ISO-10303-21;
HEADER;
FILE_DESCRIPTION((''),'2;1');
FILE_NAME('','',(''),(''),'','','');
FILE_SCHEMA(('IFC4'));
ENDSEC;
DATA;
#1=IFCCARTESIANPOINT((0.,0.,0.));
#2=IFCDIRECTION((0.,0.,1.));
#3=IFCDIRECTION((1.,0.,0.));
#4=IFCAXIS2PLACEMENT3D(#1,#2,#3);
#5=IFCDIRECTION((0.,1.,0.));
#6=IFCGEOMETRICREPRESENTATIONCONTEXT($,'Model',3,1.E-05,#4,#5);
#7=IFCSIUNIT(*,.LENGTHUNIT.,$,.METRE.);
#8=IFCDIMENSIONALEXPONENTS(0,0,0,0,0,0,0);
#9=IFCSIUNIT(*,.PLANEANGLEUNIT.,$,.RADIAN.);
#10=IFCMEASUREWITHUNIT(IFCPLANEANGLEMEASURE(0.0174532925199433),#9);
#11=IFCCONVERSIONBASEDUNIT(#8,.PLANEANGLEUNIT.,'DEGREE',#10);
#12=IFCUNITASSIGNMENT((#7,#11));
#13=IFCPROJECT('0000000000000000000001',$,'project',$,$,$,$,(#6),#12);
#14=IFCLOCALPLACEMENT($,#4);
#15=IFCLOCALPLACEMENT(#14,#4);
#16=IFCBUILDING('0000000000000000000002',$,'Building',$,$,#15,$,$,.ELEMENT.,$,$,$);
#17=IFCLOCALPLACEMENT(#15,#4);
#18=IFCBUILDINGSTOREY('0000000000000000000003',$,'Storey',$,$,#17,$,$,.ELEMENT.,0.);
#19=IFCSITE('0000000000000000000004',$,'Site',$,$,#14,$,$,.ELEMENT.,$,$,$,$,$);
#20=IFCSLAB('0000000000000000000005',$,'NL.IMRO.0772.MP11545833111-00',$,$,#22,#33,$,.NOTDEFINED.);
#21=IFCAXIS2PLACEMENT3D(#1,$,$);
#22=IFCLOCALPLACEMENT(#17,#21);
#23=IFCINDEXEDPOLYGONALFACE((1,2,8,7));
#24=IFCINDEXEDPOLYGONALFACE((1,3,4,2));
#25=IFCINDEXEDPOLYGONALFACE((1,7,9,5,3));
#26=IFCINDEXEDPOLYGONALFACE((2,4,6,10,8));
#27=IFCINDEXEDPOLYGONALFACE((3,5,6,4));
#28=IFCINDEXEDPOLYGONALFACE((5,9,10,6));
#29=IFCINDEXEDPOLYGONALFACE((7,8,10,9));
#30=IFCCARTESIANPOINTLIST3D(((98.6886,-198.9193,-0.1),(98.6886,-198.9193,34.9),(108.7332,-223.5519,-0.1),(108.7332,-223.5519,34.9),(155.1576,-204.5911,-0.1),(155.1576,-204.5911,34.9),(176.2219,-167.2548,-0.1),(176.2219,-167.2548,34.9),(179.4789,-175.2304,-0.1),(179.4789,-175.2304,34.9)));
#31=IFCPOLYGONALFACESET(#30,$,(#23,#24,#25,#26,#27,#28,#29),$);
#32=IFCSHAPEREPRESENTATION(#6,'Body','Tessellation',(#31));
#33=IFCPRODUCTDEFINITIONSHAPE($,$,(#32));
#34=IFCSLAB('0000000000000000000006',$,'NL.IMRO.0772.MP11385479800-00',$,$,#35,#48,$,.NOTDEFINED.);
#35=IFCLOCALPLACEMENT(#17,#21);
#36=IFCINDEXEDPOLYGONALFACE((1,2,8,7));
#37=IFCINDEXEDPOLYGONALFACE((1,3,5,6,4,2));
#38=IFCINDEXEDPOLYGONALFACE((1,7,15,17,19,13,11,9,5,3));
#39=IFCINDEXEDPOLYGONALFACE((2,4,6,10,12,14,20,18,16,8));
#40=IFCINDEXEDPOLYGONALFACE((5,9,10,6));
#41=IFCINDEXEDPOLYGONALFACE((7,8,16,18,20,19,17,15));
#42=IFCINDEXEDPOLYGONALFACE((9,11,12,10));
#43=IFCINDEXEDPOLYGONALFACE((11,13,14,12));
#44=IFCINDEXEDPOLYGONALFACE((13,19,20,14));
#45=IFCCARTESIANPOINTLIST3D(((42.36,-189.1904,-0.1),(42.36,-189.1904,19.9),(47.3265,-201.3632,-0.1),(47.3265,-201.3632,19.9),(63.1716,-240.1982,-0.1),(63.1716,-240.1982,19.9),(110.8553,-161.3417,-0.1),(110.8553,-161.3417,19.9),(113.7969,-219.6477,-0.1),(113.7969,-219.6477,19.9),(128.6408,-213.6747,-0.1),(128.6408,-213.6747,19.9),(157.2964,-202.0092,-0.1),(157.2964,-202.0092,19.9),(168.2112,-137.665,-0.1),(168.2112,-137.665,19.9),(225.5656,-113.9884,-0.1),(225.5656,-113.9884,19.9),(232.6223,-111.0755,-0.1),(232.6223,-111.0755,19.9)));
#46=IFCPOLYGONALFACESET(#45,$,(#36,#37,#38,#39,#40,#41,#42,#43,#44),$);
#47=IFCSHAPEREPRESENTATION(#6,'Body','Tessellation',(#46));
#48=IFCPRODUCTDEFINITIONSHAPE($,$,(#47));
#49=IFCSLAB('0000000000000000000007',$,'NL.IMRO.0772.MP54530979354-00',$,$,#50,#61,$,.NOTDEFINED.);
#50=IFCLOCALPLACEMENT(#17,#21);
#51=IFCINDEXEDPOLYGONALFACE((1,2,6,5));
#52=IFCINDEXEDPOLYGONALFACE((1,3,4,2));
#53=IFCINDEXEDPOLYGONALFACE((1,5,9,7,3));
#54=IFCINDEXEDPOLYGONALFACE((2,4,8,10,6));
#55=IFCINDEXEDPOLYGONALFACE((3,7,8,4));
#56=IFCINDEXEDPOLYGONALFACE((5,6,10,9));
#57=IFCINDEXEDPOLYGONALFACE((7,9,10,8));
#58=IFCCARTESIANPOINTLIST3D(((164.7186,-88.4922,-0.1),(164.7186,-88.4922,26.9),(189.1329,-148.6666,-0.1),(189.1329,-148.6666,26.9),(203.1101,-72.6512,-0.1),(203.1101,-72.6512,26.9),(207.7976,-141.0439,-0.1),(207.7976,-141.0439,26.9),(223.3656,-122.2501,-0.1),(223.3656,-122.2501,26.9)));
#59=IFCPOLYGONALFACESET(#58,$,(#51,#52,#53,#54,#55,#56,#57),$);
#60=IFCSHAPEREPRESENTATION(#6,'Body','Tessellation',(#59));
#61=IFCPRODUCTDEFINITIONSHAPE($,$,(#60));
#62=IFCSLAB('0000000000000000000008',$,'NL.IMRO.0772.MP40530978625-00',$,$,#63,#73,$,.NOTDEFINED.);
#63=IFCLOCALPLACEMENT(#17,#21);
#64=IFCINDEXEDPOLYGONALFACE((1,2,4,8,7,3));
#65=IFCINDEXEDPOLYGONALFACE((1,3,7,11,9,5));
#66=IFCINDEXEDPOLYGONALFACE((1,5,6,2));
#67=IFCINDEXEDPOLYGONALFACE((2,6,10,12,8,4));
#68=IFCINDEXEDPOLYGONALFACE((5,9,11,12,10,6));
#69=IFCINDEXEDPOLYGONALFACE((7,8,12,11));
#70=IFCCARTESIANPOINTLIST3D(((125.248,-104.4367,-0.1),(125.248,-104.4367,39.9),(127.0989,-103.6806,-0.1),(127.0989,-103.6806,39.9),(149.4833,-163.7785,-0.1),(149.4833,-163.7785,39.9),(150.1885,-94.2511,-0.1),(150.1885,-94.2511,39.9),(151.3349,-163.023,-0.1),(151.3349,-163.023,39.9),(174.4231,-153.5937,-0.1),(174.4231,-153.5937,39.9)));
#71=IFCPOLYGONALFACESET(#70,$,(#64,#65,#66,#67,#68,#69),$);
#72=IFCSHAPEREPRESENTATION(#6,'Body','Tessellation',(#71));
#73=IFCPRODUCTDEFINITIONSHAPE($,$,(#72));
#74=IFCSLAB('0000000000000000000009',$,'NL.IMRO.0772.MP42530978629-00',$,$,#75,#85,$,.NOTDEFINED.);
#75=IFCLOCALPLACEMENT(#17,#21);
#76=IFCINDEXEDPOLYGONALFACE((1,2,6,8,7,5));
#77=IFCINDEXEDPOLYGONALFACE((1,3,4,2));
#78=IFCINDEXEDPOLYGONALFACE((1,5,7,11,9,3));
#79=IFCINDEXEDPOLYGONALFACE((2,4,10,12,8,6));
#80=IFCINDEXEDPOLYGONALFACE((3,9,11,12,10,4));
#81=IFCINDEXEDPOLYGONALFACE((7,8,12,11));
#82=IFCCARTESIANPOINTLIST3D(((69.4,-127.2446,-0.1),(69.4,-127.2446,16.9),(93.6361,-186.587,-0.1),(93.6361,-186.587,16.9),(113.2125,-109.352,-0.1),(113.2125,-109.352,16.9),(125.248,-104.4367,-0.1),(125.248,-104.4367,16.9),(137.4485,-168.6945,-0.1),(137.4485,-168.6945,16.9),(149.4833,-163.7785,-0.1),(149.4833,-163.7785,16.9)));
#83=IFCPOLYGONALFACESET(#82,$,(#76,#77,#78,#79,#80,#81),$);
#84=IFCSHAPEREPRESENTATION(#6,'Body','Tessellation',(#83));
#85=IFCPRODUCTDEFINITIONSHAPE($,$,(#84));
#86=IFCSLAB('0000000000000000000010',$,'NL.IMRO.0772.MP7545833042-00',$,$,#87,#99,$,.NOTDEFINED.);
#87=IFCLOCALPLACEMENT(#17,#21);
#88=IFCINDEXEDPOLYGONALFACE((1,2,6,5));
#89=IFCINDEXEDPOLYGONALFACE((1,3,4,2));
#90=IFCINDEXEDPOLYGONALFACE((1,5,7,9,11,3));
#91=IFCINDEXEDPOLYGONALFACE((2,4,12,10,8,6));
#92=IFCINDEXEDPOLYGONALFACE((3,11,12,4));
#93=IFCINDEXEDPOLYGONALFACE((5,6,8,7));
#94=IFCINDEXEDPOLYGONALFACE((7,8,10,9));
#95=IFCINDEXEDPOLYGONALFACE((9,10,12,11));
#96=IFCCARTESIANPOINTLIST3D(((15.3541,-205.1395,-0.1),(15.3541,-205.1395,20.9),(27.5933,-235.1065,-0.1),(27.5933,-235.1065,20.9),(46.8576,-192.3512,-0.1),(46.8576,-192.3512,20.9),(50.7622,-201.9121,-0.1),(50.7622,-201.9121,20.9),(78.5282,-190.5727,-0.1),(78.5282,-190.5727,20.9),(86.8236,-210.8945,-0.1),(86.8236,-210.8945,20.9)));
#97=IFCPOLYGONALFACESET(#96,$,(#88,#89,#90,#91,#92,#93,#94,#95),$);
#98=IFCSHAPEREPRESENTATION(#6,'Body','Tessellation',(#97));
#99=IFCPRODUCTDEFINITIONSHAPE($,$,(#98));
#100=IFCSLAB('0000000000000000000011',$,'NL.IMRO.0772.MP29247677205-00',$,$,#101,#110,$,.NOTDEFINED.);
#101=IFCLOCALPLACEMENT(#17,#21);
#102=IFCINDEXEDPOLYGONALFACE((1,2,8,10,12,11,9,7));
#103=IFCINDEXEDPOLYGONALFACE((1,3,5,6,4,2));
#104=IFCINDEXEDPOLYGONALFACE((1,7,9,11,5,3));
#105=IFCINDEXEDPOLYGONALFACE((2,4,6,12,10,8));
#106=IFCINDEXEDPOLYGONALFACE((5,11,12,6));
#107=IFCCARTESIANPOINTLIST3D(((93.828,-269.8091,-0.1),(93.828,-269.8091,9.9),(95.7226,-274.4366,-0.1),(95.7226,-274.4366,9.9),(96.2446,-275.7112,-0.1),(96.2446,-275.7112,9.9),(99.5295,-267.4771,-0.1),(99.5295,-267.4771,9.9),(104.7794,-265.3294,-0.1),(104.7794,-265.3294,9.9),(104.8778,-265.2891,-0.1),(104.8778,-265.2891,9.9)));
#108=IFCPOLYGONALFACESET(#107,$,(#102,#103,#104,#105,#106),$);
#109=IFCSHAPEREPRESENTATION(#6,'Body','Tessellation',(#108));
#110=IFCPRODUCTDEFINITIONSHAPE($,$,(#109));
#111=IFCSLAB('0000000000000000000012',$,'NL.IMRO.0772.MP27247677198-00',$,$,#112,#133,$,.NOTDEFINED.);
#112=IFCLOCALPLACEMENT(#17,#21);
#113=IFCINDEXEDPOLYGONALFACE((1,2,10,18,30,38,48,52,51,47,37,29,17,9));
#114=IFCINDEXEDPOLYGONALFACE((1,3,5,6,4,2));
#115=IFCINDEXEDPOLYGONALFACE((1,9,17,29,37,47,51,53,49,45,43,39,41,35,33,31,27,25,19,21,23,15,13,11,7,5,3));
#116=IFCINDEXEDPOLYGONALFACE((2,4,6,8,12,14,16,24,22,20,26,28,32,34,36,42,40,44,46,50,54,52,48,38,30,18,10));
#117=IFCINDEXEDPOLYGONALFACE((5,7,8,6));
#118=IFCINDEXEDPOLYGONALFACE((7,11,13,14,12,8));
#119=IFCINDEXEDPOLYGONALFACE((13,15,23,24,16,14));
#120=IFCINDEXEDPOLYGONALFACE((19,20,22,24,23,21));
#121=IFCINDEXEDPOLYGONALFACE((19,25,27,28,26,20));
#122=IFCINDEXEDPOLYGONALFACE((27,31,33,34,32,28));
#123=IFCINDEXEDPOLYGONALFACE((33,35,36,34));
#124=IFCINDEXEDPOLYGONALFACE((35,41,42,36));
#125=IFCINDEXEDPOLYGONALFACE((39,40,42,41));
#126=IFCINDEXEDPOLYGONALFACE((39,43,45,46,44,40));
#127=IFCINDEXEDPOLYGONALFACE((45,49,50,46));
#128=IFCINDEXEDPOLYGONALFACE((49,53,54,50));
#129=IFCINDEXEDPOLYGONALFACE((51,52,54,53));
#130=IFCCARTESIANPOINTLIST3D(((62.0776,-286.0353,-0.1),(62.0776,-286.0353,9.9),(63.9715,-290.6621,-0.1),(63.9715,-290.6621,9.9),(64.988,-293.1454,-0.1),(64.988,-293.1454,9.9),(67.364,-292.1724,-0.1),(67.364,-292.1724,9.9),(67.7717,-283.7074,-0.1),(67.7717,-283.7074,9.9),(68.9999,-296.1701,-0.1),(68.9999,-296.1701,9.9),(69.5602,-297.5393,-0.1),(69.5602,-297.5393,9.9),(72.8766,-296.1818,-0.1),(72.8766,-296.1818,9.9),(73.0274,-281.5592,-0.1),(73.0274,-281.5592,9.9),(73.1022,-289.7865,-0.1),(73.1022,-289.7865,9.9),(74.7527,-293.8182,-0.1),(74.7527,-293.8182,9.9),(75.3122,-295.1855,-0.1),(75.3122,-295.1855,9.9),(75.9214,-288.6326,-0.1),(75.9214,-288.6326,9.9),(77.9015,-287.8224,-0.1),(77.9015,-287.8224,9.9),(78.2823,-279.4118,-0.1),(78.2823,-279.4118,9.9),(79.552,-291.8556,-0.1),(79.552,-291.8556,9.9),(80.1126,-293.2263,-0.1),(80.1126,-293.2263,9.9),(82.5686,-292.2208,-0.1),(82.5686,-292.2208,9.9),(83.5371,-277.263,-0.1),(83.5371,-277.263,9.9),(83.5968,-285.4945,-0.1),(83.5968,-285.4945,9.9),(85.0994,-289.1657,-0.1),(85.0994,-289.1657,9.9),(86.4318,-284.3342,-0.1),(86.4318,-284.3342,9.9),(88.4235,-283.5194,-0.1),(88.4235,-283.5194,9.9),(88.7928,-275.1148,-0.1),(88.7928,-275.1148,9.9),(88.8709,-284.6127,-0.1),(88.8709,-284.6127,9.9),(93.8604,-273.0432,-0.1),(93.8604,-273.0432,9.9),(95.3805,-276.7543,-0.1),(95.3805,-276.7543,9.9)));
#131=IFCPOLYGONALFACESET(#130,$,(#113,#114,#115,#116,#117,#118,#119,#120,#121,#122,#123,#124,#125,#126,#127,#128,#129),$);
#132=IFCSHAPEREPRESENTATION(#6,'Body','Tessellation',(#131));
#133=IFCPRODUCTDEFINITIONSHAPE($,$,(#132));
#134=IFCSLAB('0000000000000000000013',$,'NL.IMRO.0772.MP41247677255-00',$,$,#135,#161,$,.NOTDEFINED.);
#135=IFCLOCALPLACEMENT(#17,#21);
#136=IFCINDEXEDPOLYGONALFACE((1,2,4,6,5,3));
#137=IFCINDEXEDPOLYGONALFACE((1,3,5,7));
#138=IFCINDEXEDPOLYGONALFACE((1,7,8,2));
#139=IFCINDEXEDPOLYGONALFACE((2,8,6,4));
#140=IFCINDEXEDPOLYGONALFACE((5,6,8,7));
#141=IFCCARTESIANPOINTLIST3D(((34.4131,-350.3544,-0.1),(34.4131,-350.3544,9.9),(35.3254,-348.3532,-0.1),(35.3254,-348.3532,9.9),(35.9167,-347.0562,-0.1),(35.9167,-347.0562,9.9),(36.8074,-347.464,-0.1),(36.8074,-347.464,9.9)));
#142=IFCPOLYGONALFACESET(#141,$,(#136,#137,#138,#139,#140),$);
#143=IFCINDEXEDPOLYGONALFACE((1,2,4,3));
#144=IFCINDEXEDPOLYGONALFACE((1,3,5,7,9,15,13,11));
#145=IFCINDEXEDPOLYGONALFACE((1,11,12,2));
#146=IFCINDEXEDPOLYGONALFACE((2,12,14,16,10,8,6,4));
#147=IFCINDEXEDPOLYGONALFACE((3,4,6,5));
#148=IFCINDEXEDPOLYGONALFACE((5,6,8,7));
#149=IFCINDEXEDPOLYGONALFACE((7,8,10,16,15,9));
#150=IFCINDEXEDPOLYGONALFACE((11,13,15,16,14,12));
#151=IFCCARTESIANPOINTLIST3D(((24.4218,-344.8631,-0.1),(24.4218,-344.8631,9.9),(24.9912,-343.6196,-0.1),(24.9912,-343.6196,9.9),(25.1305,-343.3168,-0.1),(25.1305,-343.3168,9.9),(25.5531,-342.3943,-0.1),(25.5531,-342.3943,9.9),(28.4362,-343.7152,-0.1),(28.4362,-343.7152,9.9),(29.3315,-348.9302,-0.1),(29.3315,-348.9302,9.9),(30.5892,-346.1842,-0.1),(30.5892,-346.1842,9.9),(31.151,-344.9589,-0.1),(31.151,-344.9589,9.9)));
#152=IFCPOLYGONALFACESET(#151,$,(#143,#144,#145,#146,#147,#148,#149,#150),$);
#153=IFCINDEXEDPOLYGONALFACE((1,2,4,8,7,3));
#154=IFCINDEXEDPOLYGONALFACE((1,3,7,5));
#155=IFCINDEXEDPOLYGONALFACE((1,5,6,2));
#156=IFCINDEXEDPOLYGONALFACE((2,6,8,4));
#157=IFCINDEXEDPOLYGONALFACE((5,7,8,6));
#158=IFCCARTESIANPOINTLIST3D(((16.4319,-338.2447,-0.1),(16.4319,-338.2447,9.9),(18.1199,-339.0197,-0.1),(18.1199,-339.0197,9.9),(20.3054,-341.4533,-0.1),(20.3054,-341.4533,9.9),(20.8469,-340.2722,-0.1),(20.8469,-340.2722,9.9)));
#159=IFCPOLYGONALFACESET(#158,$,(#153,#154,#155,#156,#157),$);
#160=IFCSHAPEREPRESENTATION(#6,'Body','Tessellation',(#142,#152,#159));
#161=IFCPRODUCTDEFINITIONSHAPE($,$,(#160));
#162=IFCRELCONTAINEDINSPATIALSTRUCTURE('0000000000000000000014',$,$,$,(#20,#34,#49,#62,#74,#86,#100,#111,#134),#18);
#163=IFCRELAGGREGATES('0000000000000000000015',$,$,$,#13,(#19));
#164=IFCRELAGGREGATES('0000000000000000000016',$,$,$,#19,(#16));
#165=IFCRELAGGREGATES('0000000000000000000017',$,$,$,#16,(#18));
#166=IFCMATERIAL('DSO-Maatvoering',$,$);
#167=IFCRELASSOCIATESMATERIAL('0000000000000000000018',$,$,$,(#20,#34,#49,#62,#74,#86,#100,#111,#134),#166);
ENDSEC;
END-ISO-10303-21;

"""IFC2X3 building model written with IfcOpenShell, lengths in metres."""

from ifc_helpers import new_model, entity, si_unit, converted_unit, direction, frame, origin_with_axes, place, context, project, spatial, polyline, outline, extrude, material, element, save


model = new_model("IFC2X3")

# Units and contexts
model_context = context("Model", 3, precision=1e-05, world=origin_with_axes(), true_north=direction((0.0, 1.0, 0.0)))
ifc_project = project(units=[si_unit("LENGTHUNIT", "METRE"), converted_unit("PLANEANGLEUNIT", "DEGREE", entity("IfcPlaneAngleMeasure", 0.0174532925199433), si_unit("PLANEANGLEUNIT", "RADIAN"), dimensions=[0, 0, 0, 0, 0, 0, 0])], contexts=[model_context])

# Site, building, storey
site_placement = place(None, origin_with_axes())
site = spatial("IfcSite", under=ifc_project, at=site_placement, Name="Site", CompositionType="ELEMENT")
building_placement = place(site_placement, origin_with_axes())
building = spatial("IfcBuilding", under=site, at=building_placement, Name="Building", CompositionType="ELEMENT")
storey_placement = place(building_placement, origin_with_axes())
storey = spatial("IfcBuildingStorey", under=building, at=storey_placement, Name="Storey", CompositionType="ELEMENT", Elevation=0.0)

# Slabs
ifc_material = material(Name="DSO-Maatvoering")
for number, where, z_axis, x_axis, name in (
    (1, (0.0, 0.0, -0.1), (0.0, 0.0, 1.0), (1.0, 0.0, 0.0), "NL.IMRO.0772.MP11545833111-00"),
):
    element("IfcSlab", number, at=place(storey_placement, frame(where, z_axis=z_axis, x_axis=x_axis)), inside=storey, material=ifc_material, Name=name, PredefinedType="NOTDEFINED", context=model_context, shape_type="SweptSolid", body=[
        extrude(outline(polyline([(108.7332, -223.5519), (98.6886, -198.9193), (176.2219, -167.2548), (179.4789, -175.2304), (155.1576, -204.5911), (108.7332, -223.5519)])), origin_with_axes(), (0.0, 0.0, 1.0), 35.0),
    ])
slab_1_placement = place(storey_placement, frame((0.0, 0.0, -0.1), z_axis=(0.0, 0.0, 1.0), x_axis=(1.0, 0.0, 0.0)))
element("IfcSlab", 2, at=slab_1_placement, inside=storey, material=ifc_material, Name="NL.IMRO.0772.MP11385479800-00", PredefinedType="NOTDEFINED", context=model_context, shape_type="SweptSolid", body=[
    extrude(outline(polyline([(128.6408, -213.6747), (113.7969, -219.6477), (63.1716, -240.1982), (47.3265, -201.3632), (42.36, -189.1904), (110.8553, -161.3417), (168.2112, -137.665), (225.5656, -113.9884), (232.6223, -111.0755), (157.2964, -202.0092), (128.6408, -213.6747)])), origin_with_axes(), (0.0, 0.0, 1.0), 20.0),
])
for number, where, z_axis, x_axis, name in (
    (3, (0.0, 0.0, -0.1), (0.0, 0.0, 1.0), (1.0, 0.0, 0.0), "NL.IMRO.0772.MP54530979354-00"),
):
    element("IfcSlab", number, at=place(storey_placement, frame(where, z_axis=z_axis, x_axis=x_axis)), inside=storey, material=ifc_material, Name=name, PredefinedType="NOTDEFINED", context=model_context, shape_type="SweptSolid", body=[
        extrude(outline(polyline([(189.1329, -148.6666), (164.7186, -88.4922), (203.1101, -72.6512), (223.3656, -122.2501), (207.7976, -141.0439), (189.1329, -148.6666)])), origin_with_axes(), (0.0, 0.0, 1.0), 27.0),
    ])
for number, where, z_axis, x_axis, name in (
    (4, (0.0, 0.0, -0.1), (0.0, 0.0, 1.0), (1.0, 0.0, 0.0), "NL.IMRO.0772.MP40530978625-00"),
):
    element("IfcSlab", number, at=place(storey_placement, frame(where, z_axis=z_axis, x_axis=x_axis)), inside=storey, material=ifc_material, Name=name, PredefinedType="NOTDEFINED", context=model_context, shape_type="SweptSolid", body=[
        extrude(outline(polyline([(125.248, -104.4367), (127.0989, -103.6806), (150.1885, -94.2511), (174.4231, -153.5937), (151.3349, -163.023), (149.4833, -163.7785), (125.248, -104.4367)])), origin_with_axes(), (0.0, 0.0, 1.0), 40.0),
    ])
for number, where, z_axis, x_axis, name in (
    (5, (0.0, 0.0, -0.1), (0.0, 0.0, 1.0), (1.0, 0.0, 0.0), "NL.IMRO.0772.MP42530978629-00"),
):
    element("IfcSlab", number, at=place(storey_placement, frame(where, z_axis=z_axis, x_axis=x_axis)), inside=storey, material=ifc_material, Name=name, PredefinedType="NOTDEFINED", context=model_context, shape_type="SweptSolid", body=[
        extrude(outline(polyline([(149.4833, -163.7785), (137.4485, -168.6945), (93.6361, -186.587), (69.4, -127.2446), (113.2125, -109.352), (125.248, -104.4367), (149.4833, -163.7785)])), origin_with_axes(), (0.0, 0.0, 1.0), 17.0),
    ])
slab_2_placement = place(storey_placement, frame((0.0, 0.0, -0.1), z_axis=(0.0, 0.0, 1.0), x_axis=(1.0, 0.0, 0.0)))
element("IfcSlab", 6, at=slab_2_placement, inside=storey, material=ifc_material, Name="NL.IMRO.0772.MP7545833042-00", PredefinedType="NOTDEFINED", context=model_context, shape_type="SweptSolid", body=[
    extrude(outline(polyline([(78.5282, -190.5727), (86.8236, -210.8945), (27.5933, -235.1065), (15.3541, -205.1395), (46.8576, -192.3512), (50.7622, -201.9121), (78.5282, -190.5727)])), origin_with_axes(), (0.0, 0.0, 1.0), 21.0),
])
slab_3_placement = place(storey_placement, frame((0.0, 0.0, -0.1), z_axis=(0.0, 0.0, 1.0), x_axis=(1.0, 0.0, 0.0)))
element("IfcSlab", 7, at=slab_3_placement, inside=storey, material=ifc_material, Name="NL.IMRO.0772.MP29247677205-00", PredefinedType="NOTDEFINED", context=model_context, shape_type="SweptSolid", body=[
    extrude(outline(polyline([(95.7226, -274.4366), (93.828, -269.8091), (99.5295, -267.4771), (104.7794, -265.3294), (104.8778, -265.2891), (96.2446, -275.7112), (95.7226, -274.4366)])), origin_with_axes(), (0.0, 0.0, 1.0), 10.0),
])
slab_4_placement = place(storey_placement, frame((0.0, 0.0, -0.1), z_axis=(0.0, 0.0, 1.0), x_axis=(1.0, 0.0, 0.0)))
element("IfcSlab", 8, at=slab_4_placement, inside=storey, material=ifc_material, Name="NL.IMRO.0772.MP27247677198-00", PredefinedType="NOTDEFINED", context=model_context, shape_type="SweptSolid", body=[
    extrude(outline(polyline([(80.1126, -293.2263), (79.552, -291.8556), (77.9015, -287.8224), (75.9214, -288.6326), (73.1022, -289.7865), (74.7527, -293.8182), (75.3122, -295.1855), (72.8766, -296.1818), (69.5602, -297.5393), (68.9999, -296.1701), (67.364, -292.1724), (64.988, -293.1454), (63.9715, -290.6621), (62.0776, -286.0353), (67.7717, -283.7074), (73.0274, -281.5592), (78.2823, -279.4118), (83.5371, -277.263), (88.7928, -275.1148), (93.8604, -273.0432), (95.3805, -276.7543), (88.8709, -284.6127), (88.4235, -283.5194), (86.4318, -284.3342), (83.5968, -285.4945), (85.0994, -289.1657), (82.5686, -292.2208), (80.1126, -293.2263)])), origin_with_axes(), (0.0, 0.0, 1.0), 10.0),
])
slab_5_placement = place(storey_placement, frame((0.0, 0.0, -0.1), z_axis=(0.0, 0.0, 1.0), x_axis=(1.0, 0.0, 0.0)))
element("IfcSlab", 9, at=slab_5_placement, inside=storey, material=ifc_material, Name="NL.IMRO.0772.MP41247677255-00", PredefinedType="NOTDEFINED", context=model_context, shape_type="SweptSolid", body=[
    extrude(outline(polyline([(35.3254, -348.3532), (35.9167, -347.0562), (36.8074, -347.464), (34.4131, -350.3544), (35.3254, -348.3532)])), origin_with_axes(), (0.0, 0.0, 1.0), 10.0),
    extrude(outline(polyline([(24.9912, -343.6196), (25.1305, -343.3168), (25.5531, -342.3943), (28.4362, -343.7152), (31.151, -344.9589), (30.5892, -346.1842), (29.3315, -348.9302), (24.4218, -344.8631), (24.9912, -343.6196)])), origin_with_axes(), (0.0, 0.0, 1.0), 10.0),
    extrude(outline(polyline([(18.1199, -339.0197), (20.8469, -340.2722), (20.3054, -341.4533), (16.4319, -338.2447), (18.1199, -339.0197)])), origin_with_axes(), (0.0, 0.0, 1.0), 10.0),
])

save(model, "model.ifc")
